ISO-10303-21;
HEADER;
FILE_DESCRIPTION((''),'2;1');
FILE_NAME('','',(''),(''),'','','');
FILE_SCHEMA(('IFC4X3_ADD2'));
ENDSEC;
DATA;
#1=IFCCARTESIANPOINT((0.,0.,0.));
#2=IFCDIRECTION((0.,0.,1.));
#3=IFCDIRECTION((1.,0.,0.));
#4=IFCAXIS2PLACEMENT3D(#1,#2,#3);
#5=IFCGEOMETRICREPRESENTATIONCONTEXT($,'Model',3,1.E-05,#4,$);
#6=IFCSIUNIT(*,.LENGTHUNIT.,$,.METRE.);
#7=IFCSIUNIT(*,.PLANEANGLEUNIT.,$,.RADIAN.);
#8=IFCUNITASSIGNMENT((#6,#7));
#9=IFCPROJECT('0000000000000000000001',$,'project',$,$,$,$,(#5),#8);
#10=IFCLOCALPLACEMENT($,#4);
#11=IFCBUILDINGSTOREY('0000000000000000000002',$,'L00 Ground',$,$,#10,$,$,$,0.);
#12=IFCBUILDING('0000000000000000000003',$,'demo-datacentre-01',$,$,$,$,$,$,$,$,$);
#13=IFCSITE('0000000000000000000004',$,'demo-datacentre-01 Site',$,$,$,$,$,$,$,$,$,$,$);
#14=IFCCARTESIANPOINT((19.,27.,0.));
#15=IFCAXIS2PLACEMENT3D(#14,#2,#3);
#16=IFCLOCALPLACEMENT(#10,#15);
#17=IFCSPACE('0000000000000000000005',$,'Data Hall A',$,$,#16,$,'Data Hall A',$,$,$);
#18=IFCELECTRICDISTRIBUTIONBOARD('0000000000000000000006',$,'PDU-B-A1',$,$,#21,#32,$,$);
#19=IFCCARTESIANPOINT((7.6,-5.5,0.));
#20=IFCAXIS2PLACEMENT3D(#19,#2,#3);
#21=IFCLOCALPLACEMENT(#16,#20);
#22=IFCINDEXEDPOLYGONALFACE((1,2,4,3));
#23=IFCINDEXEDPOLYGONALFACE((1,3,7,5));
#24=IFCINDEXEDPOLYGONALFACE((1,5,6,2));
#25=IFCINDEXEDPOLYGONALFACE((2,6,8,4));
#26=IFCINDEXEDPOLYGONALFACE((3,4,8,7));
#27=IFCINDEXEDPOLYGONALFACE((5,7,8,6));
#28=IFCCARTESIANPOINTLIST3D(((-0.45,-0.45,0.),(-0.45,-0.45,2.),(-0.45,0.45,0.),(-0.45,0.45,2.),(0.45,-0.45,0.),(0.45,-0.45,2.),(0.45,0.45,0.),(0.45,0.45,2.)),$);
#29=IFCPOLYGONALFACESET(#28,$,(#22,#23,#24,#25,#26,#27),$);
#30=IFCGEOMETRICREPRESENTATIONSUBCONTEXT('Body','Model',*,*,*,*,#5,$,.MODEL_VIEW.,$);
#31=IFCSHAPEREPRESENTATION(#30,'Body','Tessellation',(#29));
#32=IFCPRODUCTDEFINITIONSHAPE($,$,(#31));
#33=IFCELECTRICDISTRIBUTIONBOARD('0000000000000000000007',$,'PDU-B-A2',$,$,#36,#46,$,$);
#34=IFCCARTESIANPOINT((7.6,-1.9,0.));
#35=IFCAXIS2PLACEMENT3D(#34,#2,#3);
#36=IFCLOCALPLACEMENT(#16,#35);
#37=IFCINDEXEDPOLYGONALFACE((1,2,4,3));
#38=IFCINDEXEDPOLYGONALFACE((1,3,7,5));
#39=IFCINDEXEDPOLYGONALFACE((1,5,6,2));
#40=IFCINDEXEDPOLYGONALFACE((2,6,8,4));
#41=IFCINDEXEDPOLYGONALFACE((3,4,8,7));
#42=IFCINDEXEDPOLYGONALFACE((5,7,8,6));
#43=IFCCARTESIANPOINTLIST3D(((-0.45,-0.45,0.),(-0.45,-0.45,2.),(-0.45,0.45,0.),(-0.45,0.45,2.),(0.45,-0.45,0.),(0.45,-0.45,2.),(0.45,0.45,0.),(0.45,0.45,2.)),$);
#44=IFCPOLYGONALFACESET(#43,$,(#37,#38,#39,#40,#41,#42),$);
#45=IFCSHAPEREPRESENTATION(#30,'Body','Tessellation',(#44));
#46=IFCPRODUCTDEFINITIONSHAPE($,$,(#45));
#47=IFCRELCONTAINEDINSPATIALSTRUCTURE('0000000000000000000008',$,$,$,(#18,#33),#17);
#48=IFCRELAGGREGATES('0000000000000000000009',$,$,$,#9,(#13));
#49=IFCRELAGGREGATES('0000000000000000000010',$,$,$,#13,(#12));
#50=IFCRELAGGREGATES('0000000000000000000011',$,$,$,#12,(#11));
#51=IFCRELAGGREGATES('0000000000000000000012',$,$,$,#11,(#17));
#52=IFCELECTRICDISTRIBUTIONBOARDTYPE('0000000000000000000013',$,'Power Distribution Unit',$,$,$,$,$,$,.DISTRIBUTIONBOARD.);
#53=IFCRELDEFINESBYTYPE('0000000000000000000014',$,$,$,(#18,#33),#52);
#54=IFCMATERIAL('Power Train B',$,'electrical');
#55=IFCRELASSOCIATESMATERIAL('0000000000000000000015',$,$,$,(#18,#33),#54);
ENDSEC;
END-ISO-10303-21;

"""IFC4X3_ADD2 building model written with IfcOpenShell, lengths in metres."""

from ifc_helpers import new_model, si_unit, frame, origin_with_axes, place, context, subcontext, project, spatial, rectangle, extrude, material, type_object, element, save


model = new_model("IFC4X3_ADD2")

# Units and contexts
model_context = context("Model", 3, precision=1e-05, world=origin_with_axes())
body_context = subcontext(model_context, "Body", "Model", "MODEL_VIEW")
ifc_project = project(units=[si_unit("LENGTHUNIT", "METRE"), si_unit("PLANEANGLEUNIT", "RADIAN")], contexts=[model_context])

# Site, building, storey, space
site = spatial("IfcSite", under=ifc_project, Name="demo-datacentre-01 Site")
building = spatial("IfcBuilding", under=site, Name="demo-datacentre-01")
storey_placement = place(None, origin_with_axes())
storey = spatial("IfcBuildingStorey", under=building, at=storey_placement, Name="L00 Ground", Elevation=0.0)
space_placement = place(storey_placement, frame((19.0, 27.0, 0.0), z_axis=(0.0, 0.0, 1.0), x_axis=(1.0, 0.0, 0.0)))
space = spatial("IfcSpace", under=storey, at=space_placement, Name="Data Hall A", LongName="Data Hall A")

# Electric distribution boards
ifc_material_1 = material(Name="Power Train B", Category="electrical")
electric_distribution_board_type = type_object("IfcElectricDistributionBoardType", Name="Power Distribution Unit", PredefinedType="DISTRIBUTIONBOARD")
for number, where, z_axis, x_axis, name in (
    (1, (7.6, -5.5, 0.0), (0.0, 0.0, 1.0), (1.0, 0.0, 0.0), "PDU-B-A1"),
    (2, (7.6, -1.9, 0.0), (0.0, 0.0, 1.0), (1.0, 0.0, 0.0), "PDU-B-A2"),
):
    element("IfcElectricDistributionBoard", number, at=place(space_placement, frame(where, z_axis=z_axis, x_axis=x_axis)), inside=space, type_object=electric_distribution_board_type, material=ifc_material_1, Name=name, context=body_context, shape_type="SweptSolid", body=[
        extrude(rectangle(XDim=0.9, YDim=0.9), origin_with_axes(), (0.0, 0.0, 1.0), 2.0),
    ])

save(model, "model.ifc")
